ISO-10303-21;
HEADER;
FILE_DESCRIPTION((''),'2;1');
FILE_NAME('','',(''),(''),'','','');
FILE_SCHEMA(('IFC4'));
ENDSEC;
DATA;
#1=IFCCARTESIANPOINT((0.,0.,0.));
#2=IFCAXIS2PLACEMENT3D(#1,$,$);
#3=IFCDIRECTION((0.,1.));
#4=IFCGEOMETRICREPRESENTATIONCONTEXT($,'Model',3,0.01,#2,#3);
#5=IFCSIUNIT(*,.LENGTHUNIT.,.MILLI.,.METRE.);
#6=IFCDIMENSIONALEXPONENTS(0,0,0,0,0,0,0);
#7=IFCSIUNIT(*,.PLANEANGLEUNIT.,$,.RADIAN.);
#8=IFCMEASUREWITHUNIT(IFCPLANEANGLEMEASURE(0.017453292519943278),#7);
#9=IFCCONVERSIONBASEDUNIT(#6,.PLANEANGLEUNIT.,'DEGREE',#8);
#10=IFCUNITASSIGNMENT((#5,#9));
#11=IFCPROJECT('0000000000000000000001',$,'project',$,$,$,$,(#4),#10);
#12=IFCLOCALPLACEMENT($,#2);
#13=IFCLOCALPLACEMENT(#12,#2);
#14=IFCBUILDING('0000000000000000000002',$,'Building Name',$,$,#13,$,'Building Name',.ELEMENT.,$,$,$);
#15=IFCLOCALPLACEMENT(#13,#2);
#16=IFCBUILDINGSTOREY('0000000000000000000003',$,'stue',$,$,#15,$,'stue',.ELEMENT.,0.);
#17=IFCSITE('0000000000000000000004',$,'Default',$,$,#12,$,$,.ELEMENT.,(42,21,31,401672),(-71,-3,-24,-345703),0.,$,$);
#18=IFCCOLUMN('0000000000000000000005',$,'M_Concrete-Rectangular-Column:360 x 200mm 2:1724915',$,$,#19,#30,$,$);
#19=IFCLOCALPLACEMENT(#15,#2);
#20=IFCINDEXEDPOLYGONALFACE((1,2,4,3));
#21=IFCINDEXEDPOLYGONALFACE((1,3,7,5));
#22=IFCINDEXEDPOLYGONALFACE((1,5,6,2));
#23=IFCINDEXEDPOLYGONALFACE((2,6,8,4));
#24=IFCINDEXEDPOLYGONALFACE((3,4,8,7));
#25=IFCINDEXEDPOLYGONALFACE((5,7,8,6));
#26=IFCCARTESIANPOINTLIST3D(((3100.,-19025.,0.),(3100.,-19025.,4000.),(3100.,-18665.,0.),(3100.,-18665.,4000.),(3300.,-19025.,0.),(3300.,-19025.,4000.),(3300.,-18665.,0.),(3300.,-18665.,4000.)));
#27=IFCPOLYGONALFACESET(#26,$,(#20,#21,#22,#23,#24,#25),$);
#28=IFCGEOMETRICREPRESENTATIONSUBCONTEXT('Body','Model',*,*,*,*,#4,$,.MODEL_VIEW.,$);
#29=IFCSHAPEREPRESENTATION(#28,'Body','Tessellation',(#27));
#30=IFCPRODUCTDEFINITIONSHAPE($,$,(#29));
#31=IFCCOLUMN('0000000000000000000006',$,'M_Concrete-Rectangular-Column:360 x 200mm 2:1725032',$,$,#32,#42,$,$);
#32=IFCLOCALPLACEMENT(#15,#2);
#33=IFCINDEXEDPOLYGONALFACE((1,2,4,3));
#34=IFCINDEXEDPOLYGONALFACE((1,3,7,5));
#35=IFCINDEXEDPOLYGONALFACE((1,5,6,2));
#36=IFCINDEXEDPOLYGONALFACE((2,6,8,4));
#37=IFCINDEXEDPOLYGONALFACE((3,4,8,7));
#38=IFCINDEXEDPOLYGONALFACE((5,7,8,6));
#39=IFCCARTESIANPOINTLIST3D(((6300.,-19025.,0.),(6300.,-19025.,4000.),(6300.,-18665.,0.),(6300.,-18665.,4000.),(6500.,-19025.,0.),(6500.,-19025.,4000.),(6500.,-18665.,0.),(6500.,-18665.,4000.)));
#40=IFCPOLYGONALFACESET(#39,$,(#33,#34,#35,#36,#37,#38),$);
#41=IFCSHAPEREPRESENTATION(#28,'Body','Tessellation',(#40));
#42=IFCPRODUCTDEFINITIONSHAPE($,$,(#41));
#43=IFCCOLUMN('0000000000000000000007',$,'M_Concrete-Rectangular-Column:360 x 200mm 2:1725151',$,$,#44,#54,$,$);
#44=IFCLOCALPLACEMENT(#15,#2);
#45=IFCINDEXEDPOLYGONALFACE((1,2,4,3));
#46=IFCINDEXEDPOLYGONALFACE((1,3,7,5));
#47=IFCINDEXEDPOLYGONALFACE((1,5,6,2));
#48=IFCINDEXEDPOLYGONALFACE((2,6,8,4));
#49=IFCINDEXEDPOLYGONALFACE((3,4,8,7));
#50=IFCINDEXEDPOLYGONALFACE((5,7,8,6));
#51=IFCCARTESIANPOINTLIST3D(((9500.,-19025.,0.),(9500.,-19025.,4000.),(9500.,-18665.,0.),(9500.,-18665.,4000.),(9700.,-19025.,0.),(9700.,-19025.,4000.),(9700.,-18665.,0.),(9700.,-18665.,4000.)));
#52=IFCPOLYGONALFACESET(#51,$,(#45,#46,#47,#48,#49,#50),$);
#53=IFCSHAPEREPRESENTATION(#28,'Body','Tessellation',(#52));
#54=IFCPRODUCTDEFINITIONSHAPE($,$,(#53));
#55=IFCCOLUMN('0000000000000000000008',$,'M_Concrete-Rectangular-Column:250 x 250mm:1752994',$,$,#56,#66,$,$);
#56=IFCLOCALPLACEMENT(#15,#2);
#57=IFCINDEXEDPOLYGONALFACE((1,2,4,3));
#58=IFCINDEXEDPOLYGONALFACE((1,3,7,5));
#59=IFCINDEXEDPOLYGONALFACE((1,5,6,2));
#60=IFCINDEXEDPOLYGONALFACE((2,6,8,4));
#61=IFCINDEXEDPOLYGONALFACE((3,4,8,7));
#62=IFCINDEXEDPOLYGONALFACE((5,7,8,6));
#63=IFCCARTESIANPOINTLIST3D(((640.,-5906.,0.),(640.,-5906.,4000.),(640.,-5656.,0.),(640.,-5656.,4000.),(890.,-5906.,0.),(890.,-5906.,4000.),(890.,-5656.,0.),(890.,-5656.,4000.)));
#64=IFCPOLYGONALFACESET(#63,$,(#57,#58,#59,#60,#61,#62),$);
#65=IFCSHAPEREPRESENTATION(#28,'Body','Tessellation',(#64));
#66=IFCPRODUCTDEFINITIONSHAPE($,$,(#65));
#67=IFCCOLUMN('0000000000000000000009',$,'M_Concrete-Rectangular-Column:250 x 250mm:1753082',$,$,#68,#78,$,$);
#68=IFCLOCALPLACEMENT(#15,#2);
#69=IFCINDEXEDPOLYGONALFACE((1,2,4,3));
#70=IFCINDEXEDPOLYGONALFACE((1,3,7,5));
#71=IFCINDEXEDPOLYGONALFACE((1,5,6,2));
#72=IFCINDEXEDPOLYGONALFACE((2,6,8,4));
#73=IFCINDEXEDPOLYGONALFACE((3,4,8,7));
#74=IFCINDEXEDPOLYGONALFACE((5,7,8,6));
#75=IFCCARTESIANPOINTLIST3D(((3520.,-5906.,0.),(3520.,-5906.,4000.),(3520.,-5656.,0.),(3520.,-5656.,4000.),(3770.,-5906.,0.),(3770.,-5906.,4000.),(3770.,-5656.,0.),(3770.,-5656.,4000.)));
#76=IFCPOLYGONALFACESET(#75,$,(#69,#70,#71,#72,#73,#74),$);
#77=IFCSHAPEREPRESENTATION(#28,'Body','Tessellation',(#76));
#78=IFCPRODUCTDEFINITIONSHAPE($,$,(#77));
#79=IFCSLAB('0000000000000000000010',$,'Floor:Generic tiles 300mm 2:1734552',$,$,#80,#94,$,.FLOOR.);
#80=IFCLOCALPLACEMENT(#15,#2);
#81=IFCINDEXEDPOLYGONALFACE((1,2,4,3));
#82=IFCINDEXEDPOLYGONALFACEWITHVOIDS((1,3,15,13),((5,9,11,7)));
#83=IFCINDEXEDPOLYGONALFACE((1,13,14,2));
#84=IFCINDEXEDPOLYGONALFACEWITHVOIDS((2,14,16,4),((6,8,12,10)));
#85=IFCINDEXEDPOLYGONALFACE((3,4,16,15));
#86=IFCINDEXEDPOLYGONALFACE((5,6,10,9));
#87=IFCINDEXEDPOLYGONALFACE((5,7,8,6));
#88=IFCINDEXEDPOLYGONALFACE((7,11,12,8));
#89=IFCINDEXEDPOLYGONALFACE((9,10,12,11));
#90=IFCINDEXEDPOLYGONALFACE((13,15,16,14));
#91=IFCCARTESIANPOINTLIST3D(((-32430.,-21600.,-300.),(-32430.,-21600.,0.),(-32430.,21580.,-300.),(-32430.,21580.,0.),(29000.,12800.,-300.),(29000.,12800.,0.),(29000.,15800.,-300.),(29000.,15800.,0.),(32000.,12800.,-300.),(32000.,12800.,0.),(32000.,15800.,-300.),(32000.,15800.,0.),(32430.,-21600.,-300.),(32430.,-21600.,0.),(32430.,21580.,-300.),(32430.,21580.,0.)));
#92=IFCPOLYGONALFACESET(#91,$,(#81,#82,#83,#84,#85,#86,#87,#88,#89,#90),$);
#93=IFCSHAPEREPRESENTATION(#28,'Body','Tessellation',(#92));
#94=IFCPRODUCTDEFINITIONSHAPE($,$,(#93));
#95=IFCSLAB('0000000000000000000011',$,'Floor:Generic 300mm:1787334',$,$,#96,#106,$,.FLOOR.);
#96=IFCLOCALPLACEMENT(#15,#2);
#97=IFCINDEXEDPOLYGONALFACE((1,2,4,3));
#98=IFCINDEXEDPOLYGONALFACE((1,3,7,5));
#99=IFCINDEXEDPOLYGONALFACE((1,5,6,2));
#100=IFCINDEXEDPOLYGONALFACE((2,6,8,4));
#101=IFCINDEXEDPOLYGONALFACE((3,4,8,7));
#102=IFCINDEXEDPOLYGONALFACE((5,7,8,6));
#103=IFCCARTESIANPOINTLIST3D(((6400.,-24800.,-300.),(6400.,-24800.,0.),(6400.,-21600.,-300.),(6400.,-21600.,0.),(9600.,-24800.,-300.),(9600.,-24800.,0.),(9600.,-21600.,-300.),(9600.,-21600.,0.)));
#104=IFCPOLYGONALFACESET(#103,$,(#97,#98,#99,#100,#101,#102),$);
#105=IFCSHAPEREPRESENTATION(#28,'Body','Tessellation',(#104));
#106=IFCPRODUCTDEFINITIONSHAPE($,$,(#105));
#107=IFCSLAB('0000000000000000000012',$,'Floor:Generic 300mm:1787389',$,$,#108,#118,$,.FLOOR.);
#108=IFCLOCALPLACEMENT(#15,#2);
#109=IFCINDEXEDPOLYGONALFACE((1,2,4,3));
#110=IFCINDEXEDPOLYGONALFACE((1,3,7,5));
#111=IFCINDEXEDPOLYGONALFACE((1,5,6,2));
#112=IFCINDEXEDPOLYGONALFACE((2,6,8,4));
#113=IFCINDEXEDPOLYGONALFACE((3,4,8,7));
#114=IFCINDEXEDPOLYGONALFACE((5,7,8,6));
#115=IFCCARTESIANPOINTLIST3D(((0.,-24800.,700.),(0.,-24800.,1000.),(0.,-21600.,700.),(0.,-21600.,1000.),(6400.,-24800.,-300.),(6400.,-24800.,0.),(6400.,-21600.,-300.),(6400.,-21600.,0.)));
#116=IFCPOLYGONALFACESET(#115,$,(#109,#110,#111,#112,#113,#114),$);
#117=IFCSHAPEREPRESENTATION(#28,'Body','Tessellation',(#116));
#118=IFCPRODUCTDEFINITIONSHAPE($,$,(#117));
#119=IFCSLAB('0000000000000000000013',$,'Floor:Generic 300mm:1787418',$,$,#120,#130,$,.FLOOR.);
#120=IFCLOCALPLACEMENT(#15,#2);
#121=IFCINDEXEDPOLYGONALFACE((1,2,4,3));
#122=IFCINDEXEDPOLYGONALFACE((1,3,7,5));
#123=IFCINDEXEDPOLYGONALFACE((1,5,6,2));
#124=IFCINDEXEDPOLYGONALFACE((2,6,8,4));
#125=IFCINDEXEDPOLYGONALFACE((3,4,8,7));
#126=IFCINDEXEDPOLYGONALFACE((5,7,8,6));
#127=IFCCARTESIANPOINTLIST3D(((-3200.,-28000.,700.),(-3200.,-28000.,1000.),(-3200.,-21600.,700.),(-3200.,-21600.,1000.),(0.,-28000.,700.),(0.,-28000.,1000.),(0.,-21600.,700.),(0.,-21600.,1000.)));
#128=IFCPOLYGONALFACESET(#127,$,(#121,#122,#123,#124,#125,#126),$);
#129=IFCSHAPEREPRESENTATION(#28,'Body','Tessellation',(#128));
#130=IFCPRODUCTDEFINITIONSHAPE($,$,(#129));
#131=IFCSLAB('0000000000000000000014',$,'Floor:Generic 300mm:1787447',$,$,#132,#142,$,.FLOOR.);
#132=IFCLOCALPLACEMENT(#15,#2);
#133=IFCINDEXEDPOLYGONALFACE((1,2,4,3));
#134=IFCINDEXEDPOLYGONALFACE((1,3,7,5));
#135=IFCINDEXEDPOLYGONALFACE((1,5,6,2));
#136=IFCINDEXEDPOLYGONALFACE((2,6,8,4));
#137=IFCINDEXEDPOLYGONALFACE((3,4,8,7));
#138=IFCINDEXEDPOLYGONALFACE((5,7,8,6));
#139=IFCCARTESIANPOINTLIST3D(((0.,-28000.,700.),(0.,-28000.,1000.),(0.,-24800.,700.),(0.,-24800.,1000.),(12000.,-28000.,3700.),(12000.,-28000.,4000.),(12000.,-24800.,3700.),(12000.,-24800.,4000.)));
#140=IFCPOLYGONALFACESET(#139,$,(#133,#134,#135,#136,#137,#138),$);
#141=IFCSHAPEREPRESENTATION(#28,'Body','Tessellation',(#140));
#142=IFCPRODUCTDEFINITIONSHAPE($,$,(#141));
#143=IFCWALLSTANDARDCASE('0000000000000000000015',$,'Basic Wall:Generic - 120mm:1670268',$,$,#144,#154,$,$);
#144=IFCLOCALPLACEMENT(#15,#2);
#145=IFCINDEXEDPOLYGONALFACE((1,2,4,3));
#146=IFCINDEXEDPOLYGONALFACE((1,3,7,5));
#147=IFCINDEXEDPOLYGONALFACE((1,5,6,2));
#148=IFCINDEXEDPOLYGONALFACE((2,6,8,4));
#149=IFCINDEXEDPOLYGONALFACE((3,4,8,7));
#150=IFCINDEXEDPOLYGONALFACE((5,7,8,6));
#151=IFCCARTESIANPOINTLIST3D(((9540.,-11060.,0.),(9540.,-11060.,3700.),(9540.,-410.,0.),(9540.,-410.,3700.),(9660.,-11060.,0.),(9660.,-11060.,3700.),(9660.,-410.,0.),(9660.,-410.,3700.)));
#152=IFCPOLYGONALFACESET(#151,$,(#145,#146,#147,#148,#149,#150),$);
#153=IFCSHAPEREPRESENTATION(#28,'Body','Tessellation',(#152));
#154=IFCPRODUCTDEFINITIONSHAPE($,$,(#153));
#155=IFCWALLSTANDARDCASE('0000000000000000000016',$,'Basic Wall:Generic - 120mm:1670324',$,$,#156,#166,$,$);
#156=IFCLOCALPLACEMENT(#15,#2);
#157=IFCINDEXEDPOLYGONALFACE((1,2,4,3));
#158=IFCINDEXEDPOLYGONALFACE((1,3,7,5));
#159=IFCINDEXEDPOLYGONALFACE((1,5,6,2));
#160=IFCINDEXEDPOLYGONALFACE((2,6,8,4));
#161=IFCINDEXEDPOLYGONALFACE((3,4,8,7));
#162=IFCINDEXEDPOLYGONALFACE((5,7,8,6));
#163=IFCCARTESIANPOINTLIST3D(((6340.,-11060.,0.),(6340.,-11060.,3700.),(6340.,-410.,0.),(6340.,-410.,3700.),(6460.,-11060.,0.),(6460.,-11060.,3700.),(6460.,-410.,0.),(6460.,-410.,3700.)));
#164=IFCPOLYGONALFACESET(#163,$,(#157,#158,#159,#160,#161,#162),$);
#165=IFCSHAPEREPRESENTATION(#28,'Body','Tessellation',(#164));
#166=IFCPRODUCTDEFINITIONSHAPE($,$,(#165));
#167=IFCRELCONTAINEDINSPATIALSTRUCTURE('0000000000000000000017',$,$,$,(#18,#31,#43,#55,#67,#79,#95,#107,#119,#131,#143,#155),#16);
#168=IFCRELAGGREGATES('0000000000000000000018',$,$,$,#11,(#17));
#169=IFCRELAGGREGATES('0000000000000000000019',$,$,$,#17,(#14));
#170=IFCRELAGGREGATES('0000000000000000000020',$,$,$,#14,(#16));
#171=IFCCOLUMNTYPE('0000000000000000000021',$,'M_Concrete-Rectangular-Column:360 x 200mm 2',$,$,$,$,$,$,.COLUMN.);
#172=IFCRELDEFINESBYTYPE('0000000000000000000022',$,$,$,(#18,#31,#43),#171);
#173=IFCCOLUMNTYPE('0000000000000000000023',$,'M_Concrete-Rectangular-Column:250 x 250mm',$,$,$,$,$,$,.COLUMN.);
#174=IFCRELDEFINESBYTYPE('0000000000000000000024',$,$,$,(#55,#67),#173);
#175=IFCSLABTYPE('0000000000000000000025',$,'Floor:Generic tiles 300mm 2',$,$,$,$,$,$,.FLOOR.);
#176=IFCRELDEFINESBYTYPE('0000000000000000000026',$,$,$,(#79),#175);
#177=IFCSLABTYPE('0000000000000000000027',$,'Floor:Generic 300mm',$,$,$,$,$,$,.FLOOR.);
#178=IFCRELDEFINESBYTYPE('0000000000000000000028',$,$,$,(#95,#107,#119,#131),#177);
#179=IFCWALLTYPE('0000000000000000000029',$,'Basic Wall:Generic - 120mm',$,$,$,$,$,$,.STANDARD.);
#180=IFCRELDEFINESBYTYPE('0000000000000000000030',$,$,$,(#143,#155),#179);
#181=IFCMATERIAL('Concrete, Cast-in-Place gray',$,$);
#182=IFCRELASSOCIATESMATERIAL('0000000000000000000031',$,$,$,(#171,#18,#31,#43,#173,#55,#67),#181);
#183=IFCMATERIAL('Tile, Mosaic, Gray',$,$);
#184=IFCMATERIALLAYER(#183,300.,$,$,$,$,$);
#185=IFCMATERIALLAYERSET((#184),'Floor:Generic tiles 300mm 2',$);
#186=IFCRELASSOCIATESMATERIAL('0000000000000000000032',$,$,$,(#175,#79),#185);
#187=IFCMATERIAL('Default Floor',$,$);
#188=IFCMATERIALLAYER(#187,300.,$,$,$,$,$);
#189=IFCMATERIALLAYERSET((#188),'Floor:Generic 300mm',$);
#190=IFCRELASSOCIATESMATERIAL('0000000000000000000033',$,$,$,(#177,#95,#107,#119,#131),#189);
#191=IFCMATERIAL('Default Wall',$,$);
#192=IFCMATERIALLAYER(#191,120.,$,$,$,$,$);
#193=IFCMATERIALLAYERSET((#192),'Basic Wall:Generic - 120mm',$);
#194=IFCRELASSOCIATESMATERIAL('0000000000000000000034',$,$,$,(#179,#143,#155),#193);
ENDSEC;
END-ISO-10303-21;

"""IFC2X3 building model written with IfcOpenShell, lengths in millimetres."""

from ifc_helpers import new_model, entity, si_unit, converted_unit, direction, frame, frame_2d, origin, origin_2d_with_axis, place, context, subcontext, project, spatial, polyline, rectangle, extrude, boolean, clip, halfspace, bounded_halfspace, source, transform, mapped, material, layer, layer_set, layer_usage, type_object, type_shapes, element, save


model = new_model("IFC2X3")

# Units and contexts
model_context = context("Model", 3, precision=0.01, world=origin(), true_north=direction((0.0, 1.0)))
body_context = subcontext(model_context, "Body", "Model", "MODEL_VIEW")
ifc_project = project(units=[si_unit("LENGTHUNIT", "METRE", prefix="MILLI"), converted_unit("PLANEANGLEUNIT", "DEGREE", entity("IfcPlaneAngleMeasure", 0.017453292519943278), si_unit("PLANEANGLEUNIT", "RADIAN"), dimensions=[0, 0, 0, 0, 0, 0, 0])], contexts=[model_context])

# Site, building, storey
site_placement = place(None, origin())
site = spatial("IfcSite", under=ifc_project, at=site_placement, Name="Default", CompositionType="ELEMENT", RefLatitude=(42, 21, 31, 401672), RefLongitude=(-71, -3, -24, -345703), RefElevation=0.0)
building_placement = place(site_placement, origin())
building = spatial("IfcBuilding", under=site, at=building_placement, Name="Building Name", LongName="Building Name", CompositionType="ELEMENT")
storey_placement = place(building_placement, origin())
storey = spatial("IfcBuildingStorey", under=building, at=storey_placement, Name="stue", LongName="stue", CompositionType="ELEMENT", Elevation=0.0)

# Columns
ifc_material_1 = material(Name="Concrete, Cast-in-Place gray")
column_type_1 = type_object("IfcColumnType", Name="M_Concrete-Rectangular-Column:360 x 200mm 2", PredefinedType="COLUMN", material=ifc_material_1)
shared_shape_1 = source(origin(), body_context, "Body", "SweptSolid", [
    extrude(rectangle(XDim=200.0, YDim=360.0, at=origin_2d_with_axis()), frame((0.0, 0.0, 0.0), z_axis=(0.0, 0.0, 1.0), x_axis=(-1.0, 0.0, 0.0)), (0.0, 0.0, 1.0), 4000.0),
])
type_shapes(column_type_1, [shared_shape_1])
for number, where, name in (
    (1, (3200.0, -18845.0, 0.0), "M_Concrete-Rectangular-Column:360 x 200mm 2:1724915"),
    (2, (6400.0, -18845.0, 0.0), "M_Concrete-Rectangular-Column:360 x 200mm 2:1725032"),
    (3, (9600.0, -18845.0, 0.0), "M_Concrete-Rectangular-Column:360 x 200mm 2:1725151"),
):
    element("IfcColumn", number, at=place(storey_placement, frame(where)), inside=storey, type_object=column_type_1, material=ifc_material_1, Name=name, context=body_context, shape_type="MappedRepresentation", body=[
        mapped(shared_shape_1, transform((0.0, 0.0, 0.0), scale=1.0)),
    ])
column_type_2 = type_object("IfcColumnType", Name="M_Concrete-Rectangular-Column:250 x 250mm", PredefinedType="COLUMN", material=ifc_material_1)
shared_shape_2 = source(origin(), body_context, "Body", "SweptSolid", [
    extrude(rectangle(XDim=250.0, YDim=250.0, at=origin_2d_with_axis()), frame((0.0, 0.0, 0.0), z_axis=(0.0, 0.0, 1.0), x_axis=(-1.0, 0.0, 0.0)), (0.0, 0.0, 1.0), 4000.0),
])
type_shapes(column_type_2, [shared_shape_2])
for number, where, name in (
    (4, (765.0, -5781.0, 0.0), "M_Concrete-Rectangular-Column:250 x 250mm:1752994"),
    (5, (3645.0, -5781.0, 0.0), "M_Concrete-Rectangular-Column:250 x 250mm:1753082"),
):
    element("IfcColumn", number, at=place(storey_placement, frame(where)), inside=storey, type_object=column_type_2, material=ifc_material_1, Name=name, context=body_context, shape_type="MappedRepresentation", body=[
        mapped(shared_shape_2, transform((0.0, 0.0, 0.0), scale=1.0)),
    ])

# Slab, opening
ifc_material_2 = material(Name="Tile, Mosaic, Gray")
ifc_layer_1 = layer(ifc_material_2, 300.0)
ifc_layer_set_1 = layer_set([ifc_layer_1], Name="Floor:Generic tiles 300mm 2")
ifc_layer_usage_1 = layer_usage(ifc_layer_set_1, "AXIS3", "POSITIVE", 0.0)
slab_type_1 = type_object("IfcSlabType", Name="Floor:Generic tiles 300mm 2", PredefinedType="FLOOR", material=ifc_layer_set_1)
slab_1_placement = place(storey_placement, origin())
slab_1 = element("IfcSlab", 6, at=slab_1_placement, inside=storey, type_object=slab_type_1, material=ifc_layer_usage_1, Name="Floor:Generic tiles 300mm 2:1734552", PredefinedType="FLOOR", context=body_context, shape_type="CSG", body=[
    boolean("DIFFERENCE", extrude(rectangle(XDim=43180.0, YDim=64860.0, at=origin_2d_with_axis()), frame((0.0, -10.0, 0.0), z_axis=(0.0, 0.0, -1.0), x_axis=(0.0, 1.0, 0.0)), (0.0, 0.0, 1.0), 300.0), extrude(rectangle(XDim=3000.0, YDim=3000.0, at=frame_2d((0.0, 0.0), x_axis=(1.0, 0.0))), frame((30500.0, 14300.0, 0.0), z_axis=(0.0, 0.0, -1.0), x_axis=(0.0, -1.0, 0.0)), (0.0, 0.0, 1.0), 300.0)),
])
opening_1_placement = place(slab_1_placement, origin())
element("IfcOpeningElement", 7, at=opening_1_placement, cuts=slab_1, ObjectType="Opening", context=body_context, shape_type="SweptSolid", body=[
    extrude(rectangle(XDim=3000.0, YDim=3000.0, at=frame_2d((30500.0, 14300.0), x_axis=(0.0, -1.0))), origin(), (0.0, 0.0, -1.0), 300.0),
])

# Slabs
ifc_material_3 = material(Name="Default Floor")
ifc_layer_2 = layer(ifc_material_3, 300.0)
ifc_layer_set_2 = layer_set([ifc_layer_2], Name="Floor:Generic 300mm")
ifc_layer_usage_2 = layer_usage(ifc_layer_set_2, "AXIS3", "POSITIVE", 0.0)
slab_type_2 = type_object("IfcSlabType", Name="Floor:Generic 300mm", PredefinedType="FLOOR", material=ifc_layer_set_2)
slab_2_placement = place(storey_placement, origin())
element("IfcSlab", 8, at=slab_2_placement, inside=storey, type_object=slab_type_2, material=ifc_layer_usage_2, Name="Floor:Generic 300mm:1787334", PredefinedType="FLOOR", context=body_context, shape_type="SweptSolid", body=[
    extrude(rectangle(XDim=3200.0, YDim=3200.0, at=frame_2d((0.0, 0.0), x_axis=(1.0, 0.0))), frame((8000.0, -23200.0, 0.0), z_axis=(0.0, 0.0, -1.0), x_axis=(0.0, 1.0, 0.0)), (0.0, 0.0, 1.0), 300.0),
])
ifc_layer_usage_3 = layer_usage(ifc_layer_set_2, "AXIS3", "POSITIVE", 0.0)
slab_3_placement = place(storey_placement, origin())
element("IfcSlab", 9, at=slab_3_placement, inside=storey, type_object=slab_type_2, material=ifc_layer_usage_3, Name="Floor:Generic 300mm:1787389", PredefinedType="FLOOR", context=body_context, shape_type="Clipping", body=[
    clip(clip(extrude(rectangle(XDim=6477.7, YDim=3200.0, at=frame_2d((0.0, 0.0), x_axis=(0.0, 1.0))), frame((3200.0, -23200.0, 500.0), z_axis=(-0.154377, 0.0, -0.988012), x_axis=(0.0, 1.0, 0.0)), (0.0, 0.154377, 0.988012), 303.6), halfspace(frame((3200.0, -23200.0, 200.0), z_axis=(-0.154377, 0.0, -0.988012), x_axis=(0.0, 1.0, 0.0)), False)), halfspace(frame((3200.0, -23200.0, 500.0), z_axis=(0.154377, 0.0, 0.988012), x_axis=(0.0, 1.0, 0.0)), False)),
])
ifc_layer_usage_4 = layer_usage(ifc_layer_set_2, "AXIS3", "POSITIVE", 0.0)
slab_4_placement = place(storey_placement, origin())
element("IfcSlab", 10, at=slab_4_placement, inside=storey, type_object=slab_type_2, material=ifc_layer_usage_4, Name="Floor:Generic 300mm:1787418", PredefinedType="FLOOR", context=body_context, shape_type="SweptSolid", body=[
    extrude(rectangle(XDim=6400.0, YDim=3200.0, at=origin_2d_with_axis()), frame((-1600.0, -24800.0, 1000.0), z_axis=(0.0, 0.0, -1.0), x_axis=(0.0, 1.0, 0.0)), (0.0, 0.0, 1.0), 300.0),
])
ifc_layer_usage_5 = layer_usage(ifc_layer_set_2, "AXIS3", "POSITIVE", 0.0)
slab_5_placement = place(storey_placement, origin())
element("IfcSlab", 11, at=slab_5_placement, inside=storey, type_object=slab_type_2, material=ifc_layer_usage_5, Name="Floor:Generic 300mm:1787447", PredefinedType="FLOOR", context=body_context, shape_type="Clipping", body=[
    clip(clip(extrude(rectangle(XDim=12369.3, YDim=3200.0, at=frame_2d((0.0, 0.0), x_axis=(0.0, 1.0))), frame((6000.0, -26400.0, 2500.0), z_axis=(0.242536, 0.0, -0.970143), x_axis=(0.0, 1.0, 0.0)), (0.0, -0.242536, 0.970143), 309.2), halfspace(frame((6000.0, -26400.0, 2200.0), z_axis=(0.242536, 0.0, -0.970143), x_axis=(0.0, -1.0, 0.0)), False)), halfspace(frame((6000.0, -26400.0, 2500.0), z_axis=(-0.242536, 0.0, 0.970143), x_axis=(0.0, -1.0, 0.0)), False)),
])

# Walls
ifc_material_4 = material(Name="Default Wall")
ifc_layer_3 = layer(ifc_material_4, 120.0)
ifc_layer_set_3 = layer_set([ifc_layer_3], Name="Basic Wall:Generic - 120mm")
ifc_layer_usage_6 = layer_usage(ifc_layer_set_3, "AXIS2", "NEGATIVE", 60.0)
wall_type_1 = type_object("IfcWallType", Name="Basic Wall:Generic - 120mm", PredefinedType="STANDARD", material=ifc_layer_set_3)
wall_1_placement = place(storey_placement, frame((9600.0, -410.0, 0.0), z_axis=(0.0, 0.0, 1.0), x_axis=(0.0, -1.0, 0.0)))
element("IfcWallStandardCase", 12, at=wall_1_placement, inside=storey, type_object=wall_type_1, material=ifc_layer_usage_6, Name="Basic Wall:Generic - 120mm:1670268", context=body_context, shape_type="Clipping", body=[
    clip(extrude(rectangle(XDim=10650.0, YDim=120.0, at=frame_2d((5325.0, 0.0), x_axis=(-1.0, 0.0))), origin(), (0.0, 0.0, 1.0), 3700.0), bounded_halfspace(frame((0.0, -60.0, 3700.0), z_axis=(0.0, 0.0, -1.0), x_axis=(1.0, 0.0, 0.0)), True, frame((0.0, -60.0, 3700.0)), polyline([(0.0, 0.0), (10650.0, 0.0), (10650.0, 120.0), (5597.0, 120.0), (5487.0, 120.0), (0.0, 120.0), (0.0, 0.0)]))),
])
ifc_layer_usage_7 = layer_usage(ifc_layer_set_3, "AXIS2", "NEGATIVE", 60.0)
wall_2_placement = place(storey_placement, frame((6400.0, -410.0, 0.0), z_axis=(0.0, 0.0, 1.0), x_axis=(0.0, -1.0, 0.0)))
element("IfcWallStandardCase", 13, at=wall_2_placement, inside=storey, type_object=wall_type_1, material=ifc_layer_usage_7, Name="Basic Wall:Generic - 120mm:1670324", context=body_context, shape_type="Clipping", body=[
    clip(extrude(rectangle(XDim=10650.0, YDim=120.0, at=frame_2d((5325.0, 0.0), x_axis=(-1.0, 0.0))), origin(), (0.0, 0.0, 1.0), 3700.0), bounded_halfspace(frame((0.0, -60.0, 3700.0), z_axis=(0.0, 0.0, -1.0), x_axis=(1.0, 0.0, 0.0)), True, frame((0.0, -60.0, 3700.0)), polyline([(0.0, 0.0), (10650.0, 0.0), (10650.0, 120.0), (0.0, 120.0), (0.0, 0.0)]))),
])

save(model, "model.ifc")
